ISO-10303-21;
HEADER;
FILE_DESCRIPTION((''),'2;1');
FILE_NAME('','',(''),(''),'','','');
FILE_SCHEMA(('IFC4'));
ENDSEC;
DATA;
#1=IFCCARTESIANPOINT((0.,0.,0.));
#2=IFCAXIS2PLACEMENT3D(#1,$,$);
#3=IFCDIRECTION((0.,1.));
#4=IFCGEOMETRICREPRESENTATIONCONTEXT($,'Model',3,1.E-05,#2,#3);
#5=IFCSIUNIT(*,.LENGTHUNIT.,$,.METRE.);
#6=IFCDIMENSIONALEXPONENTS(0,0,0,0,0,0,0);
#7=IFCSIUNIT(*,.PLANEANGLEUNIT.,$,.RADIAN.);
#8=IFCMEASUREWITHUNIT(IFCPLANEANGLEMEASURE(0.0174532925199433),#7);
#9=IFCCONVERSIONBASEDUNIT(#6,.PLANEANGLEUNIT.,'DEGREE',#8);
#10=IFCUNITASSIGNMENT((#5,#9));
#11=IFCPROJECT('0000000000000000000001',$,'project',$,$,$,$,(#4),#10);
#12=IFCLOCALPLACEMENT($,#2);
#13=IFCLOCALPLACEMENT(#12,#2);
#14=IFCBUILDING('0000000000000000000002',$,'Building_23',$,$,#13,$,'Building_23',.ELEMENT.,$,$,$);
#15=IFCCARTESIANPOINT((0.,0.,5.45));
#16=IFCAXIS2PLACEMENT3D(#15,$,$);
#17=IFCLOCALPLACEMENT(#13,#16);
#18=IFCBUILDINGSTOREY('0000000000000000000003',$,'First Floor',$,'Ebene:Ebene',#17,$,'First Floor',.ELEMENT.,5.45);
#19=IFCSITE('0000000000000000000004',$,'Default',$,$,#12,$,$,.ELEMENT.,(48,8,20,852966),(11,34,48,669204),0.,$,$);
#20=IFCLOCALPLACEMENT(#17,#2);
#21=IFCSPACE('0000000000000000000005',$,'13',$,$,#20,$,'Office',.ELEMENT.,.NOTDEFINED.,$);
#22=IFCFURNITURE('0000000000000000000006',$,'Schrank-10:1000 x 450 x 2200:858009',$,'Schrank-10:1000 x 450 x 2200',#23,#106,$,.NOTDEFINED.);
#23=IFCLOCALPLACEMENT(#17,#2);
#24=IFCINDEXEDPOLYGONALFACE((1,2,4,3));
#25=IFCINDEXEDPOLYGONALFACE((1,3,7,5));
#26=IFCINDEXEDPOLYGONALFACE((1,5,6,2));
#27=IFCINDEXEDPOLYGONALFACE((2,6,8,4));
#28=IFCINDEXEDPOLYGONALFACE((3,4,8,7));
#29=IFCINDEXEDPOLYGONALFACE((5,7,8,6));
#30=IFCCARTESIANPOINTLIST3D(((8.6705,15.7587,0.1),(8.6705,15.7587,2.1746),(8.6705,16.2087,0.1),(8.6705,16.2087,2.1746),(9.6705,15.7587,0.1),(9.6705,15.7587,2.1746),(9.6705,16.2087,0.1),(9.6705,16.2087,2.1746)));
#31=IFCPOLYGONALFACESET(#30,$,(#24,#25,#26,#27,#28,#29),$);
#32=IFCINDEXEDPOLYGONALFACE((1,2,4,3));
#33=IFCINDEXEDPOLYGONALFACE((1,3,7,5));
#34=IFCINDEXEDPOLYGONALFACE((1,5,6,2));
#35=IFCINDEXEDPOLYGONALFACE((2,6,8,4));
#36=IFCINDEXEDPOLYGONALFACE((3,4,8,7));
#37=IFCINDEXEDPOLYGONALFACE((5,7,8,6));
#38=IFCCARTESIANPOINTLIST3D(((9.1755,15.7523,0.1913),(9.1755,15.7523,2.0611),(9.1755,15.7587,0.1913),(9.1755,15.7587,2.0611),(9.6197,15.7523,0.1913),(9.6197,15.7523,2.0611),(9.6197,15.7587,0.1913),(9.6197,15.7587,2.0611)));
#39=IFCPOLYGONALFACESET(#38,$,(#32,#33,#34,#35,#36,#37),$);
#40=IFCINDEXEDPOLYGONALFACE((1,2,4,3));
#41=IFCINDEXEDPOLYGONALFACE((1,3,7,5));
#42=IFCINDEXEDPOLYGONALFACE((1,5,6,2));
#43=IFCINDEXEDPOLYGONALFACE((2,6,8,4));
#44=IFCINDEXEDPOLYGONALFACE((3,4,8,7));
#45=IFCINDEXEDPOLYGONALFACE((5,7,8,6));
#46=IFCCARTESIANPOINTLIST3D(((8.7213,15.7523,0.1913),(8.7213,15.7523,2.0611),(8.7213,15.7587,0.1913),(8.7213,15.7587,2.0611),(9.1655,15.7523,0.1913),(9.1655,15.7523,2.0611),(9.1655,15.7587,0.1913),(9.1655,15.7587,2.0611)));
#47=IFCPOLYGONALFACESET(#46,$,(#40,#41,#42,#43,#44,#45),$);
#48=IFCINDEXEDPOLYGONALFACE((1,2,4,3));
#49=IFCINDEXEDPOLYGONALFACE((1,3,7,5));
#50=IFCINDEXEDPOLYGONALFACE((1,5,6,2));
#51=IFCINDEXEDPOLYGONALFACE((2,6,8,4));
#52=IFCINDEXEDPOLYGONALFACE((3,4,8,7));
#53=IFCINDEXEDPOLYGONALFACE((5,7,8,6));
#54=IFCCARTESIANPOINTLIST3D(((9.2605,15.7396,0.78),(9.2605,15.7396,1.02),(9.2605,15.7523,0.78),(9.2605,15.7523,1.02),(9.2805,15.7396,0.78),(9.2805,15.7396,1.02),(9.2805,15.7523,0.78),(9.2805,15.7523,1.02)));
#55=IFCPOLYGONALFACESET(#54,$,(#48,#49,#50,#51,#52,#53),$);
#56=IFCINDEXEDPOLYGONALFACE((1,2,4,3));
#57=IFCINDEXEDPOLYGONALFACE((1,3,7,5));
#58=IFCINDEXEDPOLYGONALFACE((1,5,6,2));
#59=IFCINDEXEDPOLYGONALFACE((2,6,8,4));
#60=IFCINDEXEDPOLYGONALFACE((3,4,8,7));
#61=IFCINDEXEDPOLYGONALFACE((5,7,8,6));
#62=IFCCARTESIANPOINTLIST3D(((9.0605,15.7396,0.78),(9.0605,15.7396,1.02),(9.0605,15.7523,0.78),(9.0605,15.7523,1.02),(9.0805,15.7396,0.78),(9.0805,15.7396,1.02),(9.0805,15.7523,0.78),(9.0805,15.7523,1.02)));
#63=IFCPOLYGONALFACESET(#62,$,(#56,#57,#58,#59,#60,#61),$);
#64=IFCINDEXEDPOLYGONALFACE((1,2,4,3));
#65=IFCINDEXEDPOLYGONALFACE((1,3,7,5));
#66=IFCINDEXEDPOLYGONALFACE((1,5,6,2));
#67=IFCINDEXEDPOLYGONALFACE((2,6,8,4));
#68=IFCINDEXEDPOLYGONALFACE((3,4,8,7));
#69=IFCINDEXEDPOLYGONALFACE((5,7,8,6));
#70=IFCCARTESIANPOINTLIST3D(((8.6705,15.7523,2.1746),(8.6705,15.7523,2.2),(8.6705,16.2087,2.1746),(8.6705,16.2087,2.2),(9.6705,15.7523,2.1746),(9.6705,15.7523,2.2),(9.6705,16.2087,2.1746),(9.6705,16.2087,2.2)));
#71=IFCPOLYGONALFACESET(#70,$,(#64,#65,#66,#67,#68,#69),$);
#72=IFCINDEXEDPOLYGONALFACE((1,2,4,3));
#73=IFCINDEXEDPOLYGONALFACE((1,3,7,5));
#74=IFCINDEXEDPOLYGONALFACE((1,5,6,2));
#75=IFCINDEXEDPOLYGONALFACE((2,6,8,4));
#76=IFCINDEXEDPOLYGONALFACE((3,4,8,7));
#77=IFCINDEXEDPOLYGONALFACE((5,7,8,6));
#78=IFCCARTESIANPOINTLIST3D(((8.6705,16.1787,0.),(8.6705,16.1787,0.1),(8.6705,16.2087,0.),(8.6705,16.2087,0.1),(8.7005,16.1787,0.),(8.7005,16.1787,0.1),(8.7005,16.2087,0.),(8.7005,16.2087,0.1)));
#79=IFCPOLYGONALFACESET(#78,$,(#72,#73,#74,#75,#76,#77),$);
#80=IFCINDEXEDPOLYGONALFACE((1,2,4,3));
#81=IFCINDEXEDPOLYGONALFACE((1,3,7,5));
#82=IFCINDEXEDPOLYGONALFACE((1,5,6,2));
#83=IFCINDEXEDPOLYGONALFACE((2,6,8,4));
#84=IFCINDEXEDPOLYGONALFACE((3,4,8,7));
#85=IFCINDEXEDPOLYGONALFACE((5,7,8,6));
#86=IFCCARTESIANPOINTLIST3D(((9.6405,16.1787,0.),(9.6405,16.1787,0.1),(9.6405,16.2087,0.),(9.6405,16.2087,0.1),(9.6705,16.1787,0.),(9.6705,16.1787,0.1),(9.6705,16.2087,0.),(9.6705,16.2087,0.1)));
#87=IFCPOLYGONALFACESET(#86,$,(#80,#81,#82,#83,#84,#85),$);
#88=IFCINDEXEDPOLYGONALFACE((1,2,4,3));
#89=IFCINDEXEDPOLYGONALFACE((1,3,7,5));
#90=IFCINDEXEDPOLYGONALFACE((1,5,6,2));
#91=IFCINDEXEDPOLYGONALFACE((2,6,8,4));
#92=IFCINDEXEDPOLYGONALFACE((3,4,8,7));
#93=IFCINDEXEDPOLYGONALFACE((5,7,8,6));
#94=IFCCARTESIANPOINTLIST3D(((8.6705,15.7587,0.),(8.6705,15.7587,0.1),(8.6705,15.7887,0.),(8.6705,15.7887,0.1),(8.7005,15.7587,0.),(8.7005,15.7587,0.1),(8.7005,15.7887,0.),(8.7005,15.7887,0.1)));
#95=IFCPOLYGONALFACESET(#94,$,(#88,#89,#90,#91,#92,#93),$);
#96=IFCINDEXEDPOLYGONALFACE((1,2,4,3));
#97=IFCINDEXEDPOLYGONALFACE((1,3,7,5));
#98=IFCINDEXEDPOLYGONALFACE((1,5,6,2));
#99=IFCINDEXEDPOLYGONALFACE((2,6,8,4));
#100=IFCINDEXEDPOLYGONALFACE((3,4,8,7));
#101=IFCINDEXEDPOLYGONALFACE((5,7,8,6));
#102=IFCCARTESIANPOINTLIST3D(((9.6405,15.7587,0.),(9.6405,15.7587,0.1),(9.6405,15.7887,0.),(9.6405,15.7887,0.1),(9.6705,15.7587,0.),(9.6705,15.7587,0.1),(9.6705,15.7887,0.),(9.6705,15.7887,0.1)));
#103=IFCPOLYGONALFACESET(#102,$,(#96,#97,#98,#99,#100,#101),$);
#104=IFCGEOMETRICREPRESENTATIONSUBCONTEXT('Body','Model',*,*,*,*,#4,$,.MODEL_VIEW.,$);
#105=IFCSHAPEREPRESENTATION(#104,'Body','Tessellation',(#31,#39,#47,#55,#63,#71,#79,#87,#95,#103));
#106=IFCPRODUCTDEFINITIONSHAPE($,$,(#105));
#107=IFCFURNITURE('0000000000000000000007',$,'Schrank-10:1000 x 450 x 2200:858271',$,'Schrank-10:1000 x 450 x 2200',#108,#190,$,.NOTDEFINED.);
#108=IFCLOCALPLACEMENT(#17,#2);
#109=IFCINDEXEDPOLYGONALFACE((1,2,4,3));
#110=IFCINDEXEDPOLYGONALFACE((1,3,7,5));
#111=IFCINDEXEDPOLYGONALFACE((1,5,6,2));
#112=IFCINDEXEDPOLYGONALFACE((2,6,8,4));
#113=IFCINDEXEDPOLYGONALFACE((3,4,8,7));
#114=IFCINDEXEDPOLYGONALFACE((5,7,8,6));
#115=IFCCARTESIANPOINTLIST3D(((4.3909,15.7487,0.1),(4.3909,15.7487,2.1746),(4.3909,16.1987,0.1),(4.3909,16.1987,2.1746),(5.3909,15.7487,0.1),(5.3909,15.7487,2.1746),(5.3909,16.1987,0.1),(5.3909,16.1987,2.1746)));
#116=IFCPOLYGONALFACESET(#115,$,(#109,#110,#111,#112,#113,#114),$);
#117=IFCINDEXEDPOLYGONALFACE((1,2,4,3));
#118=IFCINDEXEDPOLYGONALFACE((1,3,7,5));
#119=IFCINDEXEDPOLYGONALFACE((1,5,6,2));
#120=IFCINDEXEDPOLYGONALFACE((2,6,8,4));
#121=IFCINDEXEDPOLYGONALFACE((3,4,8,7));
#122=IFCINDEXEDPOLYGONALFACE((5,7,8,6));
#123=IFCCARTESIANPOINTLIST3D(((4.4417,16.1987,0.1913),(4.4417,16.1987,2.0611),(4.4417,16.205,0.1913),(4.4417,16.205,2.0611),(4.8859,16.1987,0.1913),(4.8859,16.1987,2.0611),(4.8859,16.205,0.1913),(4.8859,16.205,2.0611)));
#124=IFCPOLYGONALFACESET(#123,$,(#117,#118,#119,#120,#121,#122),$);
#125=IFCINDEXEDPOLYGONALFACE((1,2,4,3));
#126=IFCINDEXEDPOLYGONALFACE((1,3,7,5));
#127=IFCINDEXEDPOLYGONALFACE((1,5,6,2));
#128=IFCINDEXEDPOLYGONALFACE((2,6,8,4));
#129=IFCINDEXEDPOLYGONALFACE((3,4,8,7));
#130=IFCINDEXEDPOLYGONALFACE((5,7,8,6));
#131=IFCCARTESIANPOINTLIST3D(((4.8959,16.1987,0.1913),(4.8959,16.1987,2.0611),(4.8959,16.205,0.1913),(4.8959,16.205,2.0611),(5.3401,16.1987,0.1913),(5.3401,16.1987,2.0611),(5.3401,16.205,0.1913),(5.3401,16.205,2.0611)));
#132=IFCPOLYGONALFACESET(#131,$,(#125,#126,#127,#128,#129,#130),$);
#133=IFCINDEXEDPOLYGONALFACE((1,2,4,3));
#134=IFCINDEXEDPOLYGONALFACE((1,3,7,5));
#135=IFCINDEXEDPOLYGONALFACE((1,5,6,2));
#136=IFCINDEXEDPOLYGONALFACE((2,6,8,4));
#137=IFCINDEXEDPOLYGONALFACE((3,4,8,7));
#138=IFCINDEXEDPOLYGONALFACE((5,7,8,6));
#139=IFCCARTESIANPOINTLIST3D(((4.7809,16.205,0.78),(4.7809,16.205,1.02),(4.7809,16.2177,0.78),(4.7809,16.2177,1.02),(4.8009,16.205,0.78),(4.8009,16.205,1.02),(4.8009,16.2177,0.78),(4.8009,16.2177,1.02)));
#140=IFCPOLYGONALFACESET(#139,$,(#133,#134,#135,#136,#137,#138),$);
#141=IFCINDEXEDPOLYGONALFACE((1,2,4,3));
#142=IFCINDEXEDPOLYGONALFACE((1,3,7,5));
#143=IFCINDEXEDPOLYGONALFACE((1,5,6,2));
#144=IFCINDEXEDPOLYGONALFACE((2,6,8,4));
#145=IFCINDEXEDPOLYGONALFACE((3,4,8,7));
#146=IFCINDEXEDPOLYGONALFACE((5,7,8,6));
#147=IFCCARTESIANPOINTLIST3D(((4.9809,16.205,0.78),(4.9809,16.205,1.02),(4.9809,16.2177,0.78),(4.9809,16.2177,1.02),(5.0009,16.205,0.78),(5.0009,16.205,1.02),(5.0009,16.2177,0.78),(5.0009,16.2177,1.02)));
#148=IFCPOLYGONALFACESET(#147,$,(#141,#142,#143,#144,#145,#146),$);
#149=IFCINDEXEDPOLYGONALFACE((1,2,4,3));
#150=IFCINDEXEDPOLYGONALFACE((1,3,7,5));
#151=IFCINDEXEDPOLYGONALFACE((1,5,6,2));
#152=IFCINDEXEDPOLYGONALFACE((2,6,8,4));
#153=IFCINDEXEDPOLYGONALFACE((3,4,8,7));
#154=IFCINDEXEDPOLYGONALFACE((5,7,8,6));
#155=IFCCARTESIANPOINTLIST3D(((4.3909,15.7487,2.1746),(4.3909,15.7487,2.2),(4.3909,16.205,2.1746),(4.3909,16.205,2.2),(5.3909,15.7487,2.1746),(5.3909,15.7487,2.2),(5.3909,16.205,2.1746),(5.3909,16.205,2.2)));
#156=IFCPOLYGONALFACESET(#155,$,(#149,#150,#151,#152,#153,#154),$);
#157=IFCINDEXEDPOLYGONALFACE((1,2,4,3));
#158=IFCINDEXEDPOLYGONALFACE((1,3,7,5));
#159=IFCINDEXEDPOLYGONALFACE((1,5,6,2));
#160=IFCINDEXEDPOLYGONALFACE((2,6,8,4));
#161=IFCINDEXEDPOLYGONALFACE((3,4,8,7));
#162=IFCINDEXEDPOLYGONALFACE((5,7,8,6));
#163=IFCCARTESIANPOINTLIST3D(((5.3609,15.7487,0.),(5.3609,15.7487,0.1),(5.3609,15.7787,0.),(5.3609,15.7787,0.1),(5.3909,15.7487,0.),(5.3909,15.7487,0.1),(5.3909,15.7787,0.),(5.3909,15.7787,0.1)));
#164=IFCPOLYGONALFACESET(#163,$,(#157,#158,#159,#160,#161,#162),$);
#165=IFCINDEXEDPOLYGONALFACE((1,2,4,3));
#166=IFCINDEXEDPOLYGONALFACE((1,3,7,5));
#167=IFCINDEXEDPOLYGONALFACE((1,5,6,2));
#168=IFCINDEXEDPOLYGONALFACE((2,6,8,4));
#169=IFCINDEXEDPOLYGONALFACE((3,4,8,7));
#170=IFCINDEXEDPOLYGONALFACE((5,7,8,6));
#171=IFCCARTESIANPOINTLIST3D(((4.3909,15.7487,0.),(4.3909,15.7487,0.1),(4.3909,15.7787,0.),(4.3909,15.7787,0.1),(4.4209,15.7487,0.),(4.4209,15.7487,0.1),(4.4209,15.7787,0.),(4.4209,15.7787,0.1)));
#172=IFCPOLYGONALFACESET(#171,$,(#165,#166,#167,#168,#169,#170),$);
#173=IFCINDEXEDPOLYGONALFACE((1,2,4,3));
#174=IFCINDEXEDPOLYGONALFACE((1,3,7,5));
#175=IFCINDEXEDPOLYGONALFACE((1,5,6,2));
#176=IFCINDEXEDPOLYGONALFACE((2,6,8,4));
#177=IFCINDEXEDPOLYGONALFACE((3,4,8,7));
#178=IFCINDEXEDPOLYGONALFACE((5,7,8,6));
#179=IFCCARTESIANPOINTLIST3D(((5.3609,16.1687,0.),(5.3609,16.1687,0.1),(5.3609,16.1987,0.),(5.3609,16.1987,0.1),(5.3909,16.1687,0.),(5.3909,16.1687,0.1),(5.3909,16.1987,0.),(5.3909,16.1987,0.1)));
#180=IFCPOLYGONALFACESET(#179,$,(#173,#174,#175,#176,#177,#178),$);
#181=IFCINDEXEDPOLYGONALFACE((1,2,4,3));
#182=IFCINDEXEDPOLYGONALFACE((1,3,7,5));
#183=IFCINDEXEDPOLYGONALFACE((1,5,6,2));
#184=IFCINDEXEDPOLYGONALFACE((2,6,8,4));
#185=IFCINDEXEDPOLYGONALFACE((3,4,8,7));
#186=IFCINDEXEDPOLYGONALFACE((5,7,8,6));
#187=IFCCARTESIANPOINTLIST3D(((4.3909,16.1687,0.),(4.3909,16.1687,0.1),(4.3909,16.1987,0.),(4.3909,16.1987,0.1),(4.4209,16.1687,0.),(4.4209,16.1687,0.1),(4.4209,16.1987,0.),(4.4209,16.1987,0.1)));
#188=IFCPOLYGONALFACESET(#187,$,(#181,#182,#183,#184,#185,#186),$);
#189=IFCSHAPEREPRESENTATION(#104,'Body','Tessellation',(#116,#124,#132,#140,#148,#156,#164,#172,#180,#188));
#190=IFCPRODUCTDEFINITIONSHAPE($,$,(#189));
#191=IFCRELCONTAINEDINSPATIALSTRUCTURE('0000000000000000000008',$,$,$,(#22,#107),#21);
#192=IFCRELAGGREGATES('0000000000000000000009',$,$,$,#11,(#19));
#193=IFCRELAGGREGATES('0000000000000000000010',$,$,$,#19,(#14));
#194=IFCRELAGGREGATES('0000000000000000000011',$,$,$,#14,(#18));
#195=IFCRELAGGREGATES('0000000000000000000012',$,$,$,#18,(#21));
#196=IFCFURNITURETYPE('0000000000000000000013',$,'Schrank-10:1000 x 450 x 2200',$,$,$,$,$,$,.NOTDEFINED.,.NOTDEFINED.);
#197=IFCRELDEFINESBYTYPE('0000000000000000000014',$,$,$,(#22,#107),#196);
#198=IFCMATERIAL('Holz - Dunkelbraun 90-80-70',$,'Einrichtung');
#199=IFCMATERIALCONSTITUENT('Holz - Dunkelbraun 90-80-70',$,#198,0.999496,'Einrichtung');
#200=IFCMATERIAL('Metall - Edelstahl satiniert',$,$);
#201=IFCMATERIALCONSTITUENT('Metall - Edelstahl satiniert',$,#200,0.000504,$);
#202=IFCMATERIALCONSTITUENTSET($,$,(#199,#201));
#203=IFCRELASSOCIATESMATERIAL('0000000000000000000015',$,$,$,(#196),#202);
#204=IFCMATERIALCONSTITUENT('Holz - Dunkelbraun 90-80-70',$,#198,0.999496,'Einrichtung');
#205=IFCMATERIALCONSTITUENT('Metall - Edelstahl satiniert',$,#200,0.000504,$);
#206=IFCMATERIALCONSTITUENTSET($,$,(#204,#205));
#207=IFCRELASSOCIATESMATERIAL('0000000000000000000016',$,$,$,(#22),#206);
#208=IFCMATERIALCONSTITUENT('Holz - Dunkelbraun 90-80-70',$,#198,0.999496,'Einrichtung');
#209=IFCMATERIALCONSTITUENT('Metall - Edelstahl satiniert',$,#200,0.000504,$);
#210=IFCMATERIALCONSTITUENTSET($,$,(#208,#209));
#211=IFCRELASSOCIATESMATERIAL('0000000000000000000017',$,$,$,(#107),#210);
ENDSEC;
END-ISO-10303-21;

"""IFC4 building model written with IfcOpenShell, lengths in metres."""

from ifc_helpers import new_model, entity, si_unit, converted_unit, direction, frame, origin, place, context, subcontext, project, spatial, indexed_curve, outline, extrude, source, transform, mapped, material, constituent, constituent_set, type_object, type_shapes, element, save


model = new_model("IFC4")

# Units and contexts
model_context = context("Model", 3, precision=1e-05, world=origin(), true_north=direction((0.0, 1.0)))
body_context = subcontext(model_context, "Body", "Model", "MODEL_VIEW")
ifc_project = project(units=[si_unit("LENGTHUNIT", "METRE"), converted_unit("PLANEANGLEUNIT", "DEGREE", entity("IfcPlaneAngleMeasure", 0.0174532925199433), si_unit("PLANEANGLEUNIT", "RADIAN"), dimensions=[0, 0, 0, 0, 0, 0, 0])], contexts=[model_context])

# Site, building, storey
site_placement = place(None, origin())
site = spatial("IfcSite", under=ifc_project, at=site_placement, Name="Default", CompositionType="ELEMENT", RefLatitude=(48, 8, 20, 852966), RefLongitude=(11, 34, 48, 669204), RefElevation=0.0)
building_placement = place(site_placement, origin())
building = spatial("IfcBuilding", under=site, at=building_placement, Name="Building_23", LongName="Building_23", CompositionType="ELEMENT")
storey_placement = place(building_placement, frame((0.0, 0.0, 5.45)))
storey = spatial("IfcBuildingStorey", under=building, at=storey_placement, Name="First Floor", ObjectType="Ebene:Ebene", LongName="First Floor", CompositionType="ELEMENT", Elevation=5.45)

# Shared definitions
space_1_placement = place(storey_placement, origin())
space_1 = spatial("IfcSpace", under=storey, at=space_1_placement, Name="13", LongName="Office", CompositionType="ELEMENT", PredefinedType="NOTDEFINED")

# Furniture
ifc_material_1 = material(Name="Holz - Dunkelbraun 90-80-70", Category="Einrichtung")
ifc_constituent_1 = constituent(ifc_material_1, Name="Holz - Dunkelbraun 90-80-70", Category="Einrichtung", fraction=0.999496)
ifc_material_2 = material(Name="Metall - Edelstahl satiniert")
ifc_constituent_2 = constituent(ifc_material_2, Name="Metall - Edelstahl satiniert", fraction=0.000504)
ifc_constituent_set_1 = constituent_set(constituents=[ifc_constituent_1, ifc_constituent_2])
ifc_constituent_3 = constituent(ifc_material_1, Name="Holz - Dunkelbraun 90-80-70", Category="Einrichtung", fraction=0.999496)
ifc_constituent_4 = constituent(ifc_material_2, Name="Metall - Edelstahl satiniert", fraction=0.000504)
ifc_constituent_set_2 = constituent_set(constituents=[ifc_constituent_3, ifc_constituent_4])
furniture_type = type_object("IfcFurnitureType", Name="Schrank-10:1000 x 450 x 2200", AssemblyPlace="NOTDEFINED", PredefinedType="NOTDEFINED", material=ifc_constituent_set_2)
shared_shape_1 = source(origin(), body_context, "Body", "SweptSolid", [
    extrude(outline(indexed_curve([(-0.225, -0.5), (0.225, -0.5), (0.225, 0.5), (-0.225, 0.5), (-0.225, -0.5)], self_intersect=False)), frame((-0.2692, -0.3632, 0.1), z_axis=(0.0, 0.0, 1.0), x_axis=(0.0, 1.0, 0.0)), (0.0, 0.0, 1.0), 2.0746),
    extrude(outline(indexed_curve([(-0.0032, -0.2221), (0.0032, -0.2221), (0.0032, 0.2221), (-0.0032, 0.2221), (-0.0032, -0.2221)], self_intersect=False)), frame((-0.0421, -0.5913, 0.1913), z_axis=(0.0, 0.0, 1.0), x_axis=(0.0, 1.0, 0.0)), (0.0, 0.0, 1.0), 1.8698),
    extrude(outline(indexed_curve([(-0.0032, -0.2221), (0.0032, -0.2221), (0.0032, 0.2221), (-0.0032, 0.2221), (-0.0032, -0.2221)], self_intersect=False)), frame((-0.4963, -0.5913, 0.1913), z_axis=(0.0, 0.0, 1.0), x_axis=(0.0, 1.0, 0.0)), (0.0, 0.0, 1.0), 1.8698),
    extrude(outline(indexed_curve([(-0.0063, -0.01), (0.0063, -0.01), (0.0063, 0.01), (-0.0063, 0.01), (-0.0063, -0.01)], self_intersect=False)), frame((-0.1692, -0.6009, 0.78), z_axis=(0.0, 0.0, 1.0), x_axis=(0.0, 1.0, 0.0)), (0.0, 0.0, 1.0), 0.24),
    extrude(outline(indexed_curve([(-0.0063, -0.01), (0.0063, -0.01), (0.0063, 0.01), (-0.0063, 0.01), (-0.0063, -0.01)], self_intersect=False)), frame((-0.3692, -0.6009, 0.78), z_axis=(0.0, 0.0, 1.0), x_axis=(0.0, 1.0, 0.0)), (0.0, 0.0, 1.0), 0.24),
    extrude(outline(indexed_curve([(-0.5, -0.2282), (0.5, -0.2282), (0.5, 0.2282), (-0.5, 0.2282), (-0.5, -0.2282)], self_intersect=False)), frame((-0.2692, -0.3663, 2.1746), z_axis=(0.0, 0.0, 1.0), x_axis=(-1.0, 0.0, 0.0)), (0.0, 0.0, 1.0), 0.0254),
    extrude(outline(indexed_curve([(-0.015, -0.015), (0.015, -0.015), (0.015, 0.015), (-0.015, 0.015), (-0.015, -0.015)], self_intersect=False)), frame((-0.7542, -0.1532, 0.0), z_axis=(0.0, 0.0, 1.0), x_axis=(-1.0, 0.0, 0.0)), (0.0, 0.0, 1.0), 0.1),
    extrude(outline(indexed_curve([(-0.015, -0.015), (0.015, -0.015), (0.015, 0.015), (-0.015, 0.015), (-0.015, -0.015)], self_intersect=False)), frame((0.2158, -0.1532, 0.0), z_axis=(0.0, 0.0, 1.0), x_axis=(0.0, -1.0, 0.0)), (0.0, 0.0, 1.0), 0.1),
    extrude(outline(indexed_curve([(-0.015, -0.015), (0.015, -0.015), (0.015, 0.015), (-0.015, 0.015), (-0.015, -0.015)], self_intersect=False)), frame((-0.7542, -0.5732, 0.0), z_axis=(0.0, 0.0, 1.0), x_axis=(0.0, 1.0, 0.0)), (0.0, 0.0, 1.0), 0.1),
    extrude(outline(indexed_curve([(-0.015, -0.015), (0.015, -0.015), (0.015, 0.015), (-0.015, 0.015), (-0.015, -0.015)], self_intersect=False)), frame((0.2158, -0.5732, 0.0)), (0.0, 0.0, 1.0), 0.1),
])
type_shapes(furniture_type, [shared_shape_1])
furniture_1_placement = place(space_1_placement, frame((9.4397, 16.3469, 0.0)))
element("IfcFurniture", 1, at=furniture_1_placement, inside=space_1, type_object=furniture_type, material=ifc_constituent_set_1, Name="Schrank-10:1000 x 450 x 2200:858009", ObjectType="Schrank-10:1000 x 450 x 2200", PredefinedType="NOTDEFINED", context=body_context, shape_type="MappedRepresentation", body=[
    mapped(shared_shape_1, transform((0.0, 0.0, 0.0), scale=1.0)),
])
ifc_constituent_5 = constituent(ifc_material_1, Name="Holz - Dunkelbraun 90-80-70", Category="Einrichtung", fraction=0.999496)
ifc_constituent_6 = constituent(ifc_material_2, Name="Metall - Edelstahl satiniert", fraction=0.000504)
ifc_constituent_set_3 = constituent_set(constituents=[ifc_constituent_5, ifc_constituent_6])
furniture_2_placement = place(space_1_placement, frame((4.6217, 15.6105, 0.0), z_axis=(0.0, 0.0, 1.0), x_axis=(-1.0, 0.0, 0.0)))
element("IfcFurniture", 2, at=furniture_2_placement, inside=space_1, type_object=furniture_type, material=ifc_constituent_set_3, Name="Schrank-10:1000 x 450 x 2200:858271", ObjectType="Schrank-10:1000 x 450 x 2200", PredefinedType="NOTDEFINED", context=body_context, shape_type="MappedRepresentation", body=[
    mapped(shared_shape_1, transform((0.0, 0.0, 0.0), scale=1.0)),
])

save(model, "model.ifc")
